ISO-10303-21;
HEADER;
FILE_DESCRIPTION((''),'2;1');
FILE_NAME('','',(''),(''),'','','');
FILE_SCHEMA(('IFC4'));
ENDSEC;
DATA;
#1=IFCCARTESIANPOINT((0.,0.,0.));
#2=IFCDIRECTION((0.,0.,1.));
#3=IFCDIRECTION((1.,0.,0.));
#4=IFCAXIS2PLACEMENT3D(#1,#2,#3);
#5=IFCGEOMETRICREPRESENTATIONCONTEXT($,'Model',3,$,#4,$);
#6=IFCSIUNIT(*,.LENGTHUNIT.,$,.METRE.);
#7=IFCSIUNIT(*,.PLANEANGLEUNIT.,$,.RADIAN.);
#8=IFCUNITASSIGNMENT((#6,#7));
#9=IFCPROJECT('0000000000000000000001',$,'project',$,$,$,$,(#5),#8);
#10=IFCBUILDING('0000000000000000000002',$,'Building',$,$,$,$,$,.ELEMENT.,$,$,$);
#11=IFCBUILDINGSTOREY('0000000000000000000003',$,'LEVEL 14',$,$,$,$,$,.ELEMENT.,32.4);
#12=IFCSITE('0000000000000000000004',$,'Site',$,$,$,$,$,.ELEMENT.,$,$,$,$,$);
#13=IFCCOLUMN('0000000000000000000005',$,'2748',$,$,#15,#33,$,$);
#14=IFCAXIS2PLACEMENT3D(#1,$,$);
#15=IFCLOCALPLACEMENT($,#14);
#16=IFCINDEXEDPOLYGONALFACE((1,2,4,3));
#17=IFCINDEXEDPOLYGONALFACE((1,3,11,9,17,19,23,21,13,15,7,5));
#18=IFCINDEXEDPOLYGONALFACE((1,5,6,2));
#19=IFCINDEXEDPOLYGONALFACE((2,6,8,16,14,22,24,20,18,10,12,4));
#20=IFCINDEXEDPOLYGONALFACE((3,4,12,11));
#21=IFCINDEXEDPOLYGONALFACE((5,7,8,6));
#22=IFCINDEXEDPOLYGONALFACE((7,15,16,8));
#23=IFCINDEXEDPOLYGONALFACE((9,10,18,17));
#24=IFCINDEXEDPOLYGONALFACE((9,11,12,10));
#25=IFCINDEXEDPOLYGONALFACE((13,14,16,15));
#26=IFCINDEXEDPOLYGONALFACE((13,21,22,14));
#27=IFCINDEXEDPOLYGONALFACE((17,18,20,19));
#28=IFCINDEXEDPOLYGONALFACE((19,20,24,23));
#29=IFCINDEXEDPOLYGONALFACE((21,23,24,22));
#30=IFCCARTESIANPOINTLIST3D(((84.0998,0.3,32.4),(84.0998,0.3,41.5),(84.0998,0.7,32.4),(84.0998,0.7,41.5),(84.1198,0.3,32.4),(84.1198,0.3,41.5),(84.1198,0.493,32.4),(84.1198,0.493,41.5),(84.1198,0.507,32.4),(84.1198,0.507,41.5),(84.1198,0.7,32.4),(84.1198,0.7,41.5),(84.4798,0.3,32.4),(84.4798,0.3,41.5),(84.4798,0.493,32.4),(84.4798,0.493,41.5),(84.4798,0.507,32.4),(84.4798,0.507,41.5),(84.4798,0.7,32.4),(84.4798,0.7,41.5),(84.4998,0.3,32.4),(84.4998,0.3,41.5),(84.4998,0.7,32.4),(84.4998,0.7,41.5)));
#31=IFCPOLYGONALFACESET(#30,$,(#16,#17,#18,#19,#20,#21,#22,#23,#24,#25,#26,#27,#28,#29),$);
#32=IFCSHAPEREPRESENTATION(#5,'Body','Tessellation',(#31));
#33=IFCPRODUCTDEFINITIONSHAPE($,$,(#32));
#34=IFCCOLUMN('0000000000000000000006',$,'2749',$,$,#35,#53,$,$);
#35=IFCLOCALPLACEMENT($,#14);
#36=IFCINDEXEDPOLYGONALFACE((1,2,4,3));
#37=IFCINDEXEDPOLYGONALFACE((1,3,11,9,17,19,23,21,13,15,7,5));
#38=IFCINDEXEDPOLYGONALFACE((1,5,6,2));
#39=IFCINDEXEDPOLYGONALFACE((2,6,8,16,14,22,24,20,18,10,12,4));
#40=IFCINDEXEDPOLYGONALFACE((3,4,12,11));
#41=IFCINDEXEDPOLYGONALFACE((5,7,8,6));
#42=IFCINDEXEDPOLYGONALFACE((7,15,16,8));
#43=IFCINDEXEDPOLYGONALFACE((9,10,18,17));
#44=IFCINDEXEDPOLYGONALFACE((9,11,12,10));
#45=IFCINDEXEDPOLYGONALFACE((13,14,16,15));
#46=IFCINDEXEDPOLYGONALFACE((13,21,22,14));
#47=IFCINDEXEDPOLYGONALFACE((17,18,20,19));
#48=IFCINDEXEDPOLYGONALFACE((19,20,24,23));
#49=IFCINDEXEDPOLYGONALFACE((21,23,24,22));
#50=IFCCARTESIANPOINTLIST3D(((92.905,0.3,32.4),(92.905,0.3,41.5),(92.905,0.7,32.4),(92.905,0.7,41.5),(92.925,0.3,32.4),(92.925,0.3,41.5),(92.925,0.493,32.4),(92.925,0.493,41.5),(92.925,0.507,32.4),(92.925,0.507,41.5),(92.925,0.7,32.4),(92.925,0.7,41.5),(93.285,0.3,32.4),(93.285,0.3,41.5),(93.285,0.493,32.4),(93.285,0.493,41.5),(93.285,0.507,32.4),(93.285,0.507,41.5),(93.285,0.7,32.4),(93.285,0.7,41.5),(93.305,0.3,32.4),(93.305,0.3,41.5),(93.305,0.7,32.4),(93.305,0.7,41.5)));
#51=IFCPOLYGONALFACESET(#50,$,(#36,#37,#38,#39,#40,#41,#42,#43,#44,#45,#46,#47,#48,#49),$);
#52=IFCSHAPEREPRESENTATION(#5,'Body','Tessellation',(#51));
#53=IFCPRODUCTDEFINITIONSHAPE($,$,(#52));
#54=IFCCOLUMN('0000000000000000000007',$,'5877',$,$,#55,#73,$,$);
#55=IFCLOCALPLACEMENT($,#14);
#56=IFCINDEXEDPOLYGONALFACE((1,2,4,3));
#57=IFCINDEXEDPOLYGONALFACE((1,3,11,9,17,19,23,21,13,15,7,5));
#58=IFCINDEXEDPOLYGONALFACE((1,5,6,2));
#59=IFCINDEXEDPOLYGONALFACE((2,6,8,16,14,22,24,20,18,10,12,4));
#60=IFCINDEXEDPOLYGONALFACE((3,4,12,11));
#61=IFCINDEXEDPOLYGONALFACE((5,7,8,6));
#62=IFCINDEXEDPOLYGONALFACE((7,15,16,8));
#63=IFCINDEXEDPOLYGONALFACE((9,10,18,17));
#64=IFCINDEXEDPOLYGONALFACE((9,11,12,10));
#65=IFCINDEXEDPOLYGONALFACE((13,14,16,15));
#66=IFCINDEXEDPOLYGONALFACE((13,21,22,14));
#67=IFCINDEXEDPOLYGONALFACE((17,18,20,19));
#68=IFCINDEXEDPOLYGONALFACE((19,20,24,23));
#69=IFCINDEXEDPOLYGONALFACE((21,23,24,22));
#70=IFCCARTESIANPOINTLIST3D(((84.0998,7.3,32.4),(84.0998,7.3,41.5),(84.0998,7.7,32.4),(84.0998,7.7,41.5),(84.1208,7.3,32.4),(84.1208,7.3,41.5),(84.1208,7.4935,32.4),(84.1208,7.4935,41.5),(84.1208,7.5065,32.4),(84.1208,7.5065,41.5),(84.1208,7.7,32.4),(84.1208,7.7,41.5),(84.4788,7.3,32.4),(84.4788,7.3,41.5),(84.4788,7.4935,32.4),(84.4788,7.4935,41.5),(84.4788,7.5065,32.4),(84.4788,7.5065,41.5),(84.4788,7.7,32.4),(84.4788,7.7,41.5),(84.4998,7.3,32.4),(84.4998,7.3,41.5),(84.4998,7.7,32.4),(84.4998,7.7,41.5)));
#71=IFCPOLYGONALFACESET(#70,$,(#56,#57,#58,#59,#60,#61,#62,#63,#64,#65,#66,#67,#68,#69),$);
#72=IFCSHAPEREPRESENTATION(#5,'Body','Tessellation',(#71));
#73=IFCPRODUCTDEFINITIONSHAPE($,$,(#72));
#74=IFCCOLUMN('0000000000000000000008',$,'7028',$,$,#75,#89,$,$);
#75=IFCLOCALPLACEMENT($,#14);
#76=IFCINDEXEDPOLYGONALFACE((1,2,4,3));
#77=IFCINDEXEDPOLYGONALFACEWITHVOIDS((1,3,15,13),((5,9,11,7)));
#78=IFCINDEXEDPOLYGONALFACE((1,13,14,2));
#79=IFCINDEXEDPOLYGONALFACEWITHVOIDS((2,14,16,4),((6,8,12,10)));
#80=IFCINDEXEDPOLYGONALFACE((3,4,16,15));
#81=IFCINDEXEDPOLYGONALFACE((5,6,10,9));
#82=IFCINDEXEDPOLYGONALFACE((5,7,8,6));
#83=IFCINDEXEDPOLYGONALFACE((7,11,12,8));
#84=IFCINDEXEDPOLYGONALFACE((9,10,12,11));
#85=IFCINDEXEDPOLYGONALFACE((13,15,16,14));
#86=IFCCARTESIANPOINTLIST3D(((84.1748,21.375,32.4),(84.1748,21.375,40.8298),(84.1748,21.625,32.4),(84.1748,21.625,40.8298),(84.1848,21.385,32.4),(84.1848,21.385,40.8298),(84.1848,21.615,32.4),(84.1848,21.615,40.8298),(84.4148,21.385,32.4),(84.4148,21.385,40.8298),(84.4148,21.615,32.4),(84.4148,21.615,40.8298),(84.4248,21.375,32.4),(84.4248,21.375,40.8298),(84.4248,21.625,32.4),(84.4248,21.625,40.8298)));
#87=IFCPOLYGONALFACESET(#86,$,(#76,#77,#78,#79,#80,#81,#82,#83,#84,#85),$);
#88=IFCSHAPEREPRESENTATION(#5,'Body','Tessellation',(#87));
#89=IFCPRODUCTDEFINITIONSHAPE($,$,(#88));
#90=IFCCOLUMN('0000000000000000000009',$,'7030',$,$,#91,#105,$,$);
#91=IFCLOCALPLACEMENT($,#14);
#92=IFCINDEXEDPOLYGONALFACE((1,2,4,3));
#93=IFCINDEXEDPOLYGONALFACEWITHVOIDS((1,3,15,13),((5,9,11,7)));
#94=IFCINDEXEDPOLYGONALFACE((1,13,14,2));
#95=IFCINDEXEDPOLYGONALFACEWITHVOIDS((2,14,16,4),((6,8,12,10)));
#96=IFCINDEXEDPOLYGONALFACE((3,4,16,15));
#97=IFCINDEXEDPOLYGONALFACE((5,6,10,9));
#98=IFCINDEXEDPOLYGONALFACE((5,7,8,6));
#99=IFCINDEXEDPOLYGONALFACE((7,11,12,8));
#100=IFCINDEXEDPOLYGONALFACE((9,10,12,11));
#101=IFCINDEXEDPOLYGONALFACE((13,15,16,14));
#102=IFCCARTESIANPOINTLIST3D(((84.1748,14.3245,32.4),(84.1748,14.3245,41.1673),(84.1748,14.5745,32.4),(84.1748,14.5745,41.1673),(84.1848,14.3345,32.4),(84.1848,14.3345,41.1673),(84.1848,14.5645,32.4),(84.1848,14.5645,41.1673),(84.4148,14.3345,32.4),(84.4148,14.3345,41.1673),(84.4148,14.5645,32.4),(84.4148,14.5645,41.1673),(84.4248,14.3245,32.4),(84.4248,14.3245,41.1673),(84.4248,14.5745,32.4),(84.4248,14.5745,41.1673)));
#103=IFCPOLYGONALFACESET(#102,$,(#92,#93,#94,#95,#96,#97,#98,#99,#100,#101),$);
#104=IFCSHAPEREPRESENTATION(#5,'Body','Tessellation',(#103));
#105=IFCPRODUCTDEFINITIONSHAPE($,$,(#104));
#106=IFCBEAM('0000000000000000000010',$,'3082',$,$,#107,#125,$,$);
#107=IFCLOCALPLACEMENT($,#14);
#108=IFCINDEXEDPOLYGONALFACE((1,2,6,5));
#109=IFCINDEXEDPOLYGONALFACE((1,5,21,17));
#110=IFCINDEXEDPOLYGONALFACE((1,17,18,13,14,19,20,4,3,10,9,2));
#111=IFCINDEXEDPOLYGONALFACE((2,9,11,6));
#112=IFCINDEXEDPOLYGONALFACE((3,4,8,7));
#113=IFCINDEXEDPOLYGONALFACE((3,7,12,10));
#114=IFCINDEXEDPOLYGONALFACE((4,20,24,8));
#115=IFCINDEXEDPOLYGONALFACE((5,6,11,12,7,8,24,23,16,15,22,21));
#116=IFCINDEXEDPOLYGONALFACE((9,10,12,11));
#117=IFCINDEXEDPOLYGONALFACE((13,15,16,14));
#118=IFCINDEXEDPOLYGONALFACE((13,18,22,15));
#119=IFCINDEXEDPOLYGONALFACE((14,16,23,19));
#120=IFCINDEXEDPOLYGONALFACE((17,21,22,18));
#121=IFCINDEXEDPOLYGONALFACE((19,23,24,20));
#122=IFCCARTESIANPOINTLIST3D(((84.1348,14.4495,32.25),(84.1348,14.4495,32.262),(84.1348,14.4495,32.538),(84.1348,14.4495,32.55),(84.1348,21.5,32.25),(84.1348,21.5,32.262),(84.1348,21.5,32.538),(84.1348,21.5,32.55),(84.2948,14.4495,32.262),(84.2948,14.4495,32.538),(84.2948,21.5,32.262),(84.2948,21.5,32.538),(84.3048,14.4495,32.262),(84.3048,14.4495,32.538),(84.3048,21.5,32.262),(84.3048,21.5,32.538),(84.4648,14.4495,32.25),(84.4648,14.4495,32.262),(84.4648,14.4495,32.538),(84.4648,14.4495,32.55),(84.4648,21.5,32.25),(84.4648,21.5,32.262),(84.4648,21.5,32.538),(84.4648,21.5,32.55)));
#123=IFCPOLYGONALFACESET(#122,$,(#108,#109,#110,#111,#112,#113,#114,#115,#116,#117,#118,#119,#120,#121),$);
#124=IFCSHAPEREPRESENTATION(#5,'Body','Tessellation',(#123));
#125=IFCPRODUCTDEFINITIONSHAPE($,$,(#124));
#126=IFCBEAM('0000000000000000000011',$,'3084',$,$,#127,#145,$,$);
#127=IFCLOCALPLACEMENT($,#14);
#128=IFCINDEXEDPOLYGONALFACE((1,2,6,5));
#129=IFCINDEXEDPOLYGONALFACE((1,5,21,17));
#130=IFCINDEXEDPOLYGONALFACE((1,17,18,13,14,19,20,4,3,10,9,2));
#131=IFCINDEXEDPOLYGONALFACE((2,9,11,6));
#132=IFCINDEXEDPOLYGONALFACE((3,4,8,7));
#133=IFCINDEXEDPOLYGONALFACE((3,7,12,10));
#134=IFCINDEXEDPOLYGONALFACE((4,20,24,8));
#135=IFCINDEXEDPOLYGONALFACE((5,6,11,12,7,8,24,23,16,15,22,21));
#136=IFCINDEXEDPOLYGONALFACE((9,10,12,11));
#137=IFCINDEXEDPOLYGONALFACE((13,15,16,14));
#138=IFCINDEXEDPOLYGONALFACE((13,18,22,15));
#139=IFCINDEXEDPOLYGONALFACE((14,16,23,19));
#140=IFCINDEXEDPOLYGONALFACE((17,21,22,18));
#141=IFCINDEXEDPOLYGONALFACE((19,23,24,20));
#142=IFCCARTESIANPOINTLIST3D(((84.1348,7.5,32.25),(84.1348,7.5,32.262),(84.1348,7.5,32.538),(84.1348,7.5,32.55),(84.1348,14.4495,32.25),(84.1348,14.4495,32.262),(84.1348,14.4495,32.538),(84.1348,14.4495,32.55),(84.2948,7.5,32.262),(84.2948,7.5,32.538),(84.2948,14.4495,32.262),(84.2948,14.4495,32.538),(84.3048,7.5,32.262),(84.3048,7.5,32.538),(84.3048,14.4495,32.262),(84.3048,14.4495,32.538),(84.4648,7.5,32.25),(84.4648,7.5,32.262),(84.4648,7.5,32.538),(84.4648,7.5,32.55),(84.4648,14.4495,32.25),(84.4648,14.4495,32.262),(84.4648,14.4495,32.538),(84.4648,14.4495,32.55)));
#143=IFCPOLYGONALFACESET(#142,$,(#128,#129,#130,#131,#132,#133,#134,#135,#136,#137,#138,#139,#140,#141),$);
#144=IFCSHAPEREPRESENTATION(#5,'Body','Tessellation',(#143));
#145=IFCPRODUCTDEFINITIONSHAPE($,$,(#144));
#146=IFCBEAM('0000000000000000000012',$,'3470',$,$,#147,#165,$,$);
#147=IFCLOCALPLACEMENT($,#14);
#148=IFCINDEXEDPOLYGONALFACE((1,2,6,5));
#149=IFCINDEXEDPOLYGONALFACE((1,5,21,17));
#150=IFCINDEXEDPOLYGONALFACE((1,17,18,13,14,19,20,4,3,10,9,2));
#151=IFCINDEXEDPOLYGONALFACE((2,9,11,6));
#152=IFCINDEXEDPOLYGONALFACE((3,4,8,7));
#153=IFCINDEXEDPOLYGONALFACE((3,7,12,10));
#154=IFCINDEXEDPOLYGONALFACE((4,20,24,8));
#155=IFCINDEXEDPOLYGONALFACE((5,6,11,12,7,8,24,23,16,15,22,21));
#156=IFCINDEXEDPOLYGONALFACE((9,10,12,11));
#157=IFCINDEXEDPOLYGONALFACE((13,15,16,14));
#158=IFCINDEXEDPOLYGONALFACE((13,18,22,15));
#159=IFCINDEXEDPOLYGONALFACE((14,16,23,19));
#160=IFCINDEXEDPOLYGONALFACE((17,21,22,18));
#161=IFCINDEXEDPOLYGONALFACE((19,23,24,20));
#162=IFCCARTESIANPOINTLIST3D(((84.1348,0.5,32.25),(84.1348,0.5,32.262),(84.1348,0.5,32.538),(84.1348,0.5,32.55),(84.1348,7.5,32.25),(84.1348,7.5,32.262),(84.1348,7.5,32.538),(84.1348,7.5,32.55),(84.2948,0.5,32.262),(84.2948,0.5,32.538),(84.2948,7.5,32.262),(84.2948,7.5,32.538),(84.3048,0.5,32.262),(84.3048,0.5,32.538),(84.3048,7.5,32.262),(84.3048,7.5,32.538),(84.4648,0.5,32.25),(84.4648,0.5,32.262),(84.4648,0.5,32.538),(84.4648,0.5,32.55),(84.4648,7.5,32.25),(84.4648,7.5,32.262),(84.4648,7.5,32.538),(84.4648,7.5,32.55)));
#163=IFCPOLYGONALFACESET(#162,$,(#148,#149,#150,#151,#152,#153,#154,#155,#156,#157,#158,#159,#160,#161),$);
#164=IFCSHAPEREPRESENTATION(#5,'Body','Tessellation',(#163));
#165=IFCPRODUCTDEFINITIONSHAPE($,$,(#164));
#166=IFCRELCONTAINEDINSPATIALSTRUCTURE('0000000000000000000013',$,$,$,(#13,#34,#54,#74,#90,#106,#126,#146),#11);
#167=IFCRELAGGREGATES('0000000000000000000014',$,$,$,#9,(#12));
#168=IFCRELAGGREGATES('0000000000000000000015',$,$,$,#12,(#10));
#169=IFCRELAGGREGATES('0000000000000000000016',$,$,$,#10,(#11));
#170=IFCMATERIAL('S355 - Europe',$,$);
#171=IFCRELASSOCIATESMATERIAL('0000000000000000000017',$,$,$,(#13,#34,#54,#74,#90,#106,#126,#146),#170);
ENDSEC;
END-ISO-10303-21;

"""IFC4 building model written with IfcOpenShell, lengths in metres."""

from ifc_helpers import new_model, si_unit, frame, origin_with_axes, origin_2d_with_axis, place, context, project, spatial, hollow_rectangle, i_section, extrude, material, material_profile, profile_set, profile_usage, element, save


model = new_model("IFC4")

# Units and contexts
model_context = context("Model", 3, world=origin_with_axes())
ifc_project = project(units=[si_unit("LENGTHUNIT", "METRE"), si_unit("PLANEANGLEUNIT", "RADIAN")], contexts=[model_context])

# Site, building, storey
site = spatial("IfcSite", under=ifc_project, Name="Site", CompositionType="ELEMENT")
building = spatial("IfcBuilding", under=site, Name="Building", CompositionType="ELEMENT")
storey = spatial("IfcBuildingStorey", under=building, Name="LEVEL 14", CompositionType="ELEMENT", Elevation=32.4)

# Columns
ifc_material = material(Name="S355 - Europe")
ifc_material_profile_1 = material_profile(ifc_material, i_section(OverallWidth=0.4, OverallDepth=0.4, WebThickness=0.014, FlangeThickness=0.02, at=origin_2d_with_axis()))
ifc_profile_set_1 = profile_set([ifc_material_profile_1])
ifc_profile_usage_1 = profile_usage(ifc_profile_set_1, cardinal=10)
column_1_placement = place(None, frame((84.2998, 0.5, 32.4), z_axis=(0.0, 0.0, 1.0), x_axis=(0.0, -1.0, 0.0)))
element("IfcColumn", 1, at=column_1_placement, inside=storey, material=ifc_profile_usage_1, Name="2748", context=model_context, shape_type="SweptSolid", body=[
    extrude(i_section(OverallWidth=0.4, OverallDepth=0.4, WebThickness=0.014, FlangeThickness=0.02, at=origin_2d_with_axis()), origin_with_axes(), (0.0, 0.0, 1.0), 9.1),
])
ifc_material_profile_2 = material_profile(ifc_material, i_section(OverallWidth=0.4, OverallDepth=0.4, WebThickness=0.014, FlangeThickness=0.02, at=origin_2d_with_axis()))
ifc_profile_set_2 = profile_set([ifc_material_profile_2])
ifc_profile_usage_2 = profile_usage(ifc_profile_set_2, cardinal=10)
column_2_placement = place(None, frame((93.105, 0.5, 32.4), z_axis=(0.0, 0.0, 1.0), x_axis=(0.0, -1.0, 0.0)))
element("IfcColumn", 2, at=column_2_placement, inside=storey, material=ifc_profile_usage_2, Name="2749", context=model_context, shape_type="SweptSolid", body=[
    extrude(i_section(OverallWidth=0.4, OverallDepth=0.4, WebThickness=0.014, FlangeThickness=0.02, at=origin_2d_with_axis()), origin_with_axes(), (0.0, 0.0, 1.0), 9.1),
])
ifc_material_profile_3 = material_profile(ifc_material, i_section(OverallWidth=0.4, OverallDepth=0.4, WebThickness=0.013, FlangeThickness=0.021, at=origin_2d_with_axis()))
ifc_profile_set_3 = profile_set([ifc_material_profile_3])
ifc_profile_usage_3 = profile_usage(ifc_profile_set_3, cardinal=10)
column_3_placement = place(None, frame((84.2998, 7.5, 32.4), z_axis=(0.0, 0.0, 1.0), x_axis=(0.0, -1.0, 0.0)))
element("IfcColumn", 3, at=column_3_placement, inside=storey, material=ifc_profile_usage_3, Name="5877", context=model_context, shape_type="SweptSolid", body=[
    extrude(i_section(OverallWidth=0.4, OverallDepth=0.4, WebThickness=0.013, FlangeThickness=0.021, at=origin_2d_with_axis()), origin_with_axes(), (0.0, 0.0, 1.0), 9.1),
])
ifc_material_profile_4 = material_profile(ifc_material, hollow_rectangle(XDim=0.25, YDim=0.25, WallThickness=0.01, at=origin_2d_with_axis()))
ifc_profile_set_4 = profile_set([ifc_material_profile_4])
ifc_profile_usage_4 = profile_usage(ifc_profile_set_4, cardinal=10)
column_4_placement = place(None, frame((84.2998, 21.5, 32.4), z_axis=(0.0, 0.0, 1.0), x_axis=(0.0, -1.0, 0.0)))
element("IfcColumn", 4, at=column_4_placement, inside=storey, material=ifc_profile_usage_4, Name="7028", context=model_context, shape_type="SweptSolid", body=[
    extrude(hollow_rectangle(XDim=0.25, YDim=0.25, WallThickness=0.01, at=origin_2d_with_axis()), origin_with_axes(), (0.0, 0.0, 1.0), 8.4298),
])
ifc_material_profile_5 = material_profile(ifc_material, hollow_rectangle(XDim=0.25, YDim=0.25, WallThickness=0.01, at=origin_2d_with_axis()))
ifc_profile_set_5 = profile_set([ifc_material_profile_5])
ifc_profile_usage_5 = profile_usage(ifc_profile_set_5, cardinal=10)
column_5_placement = place(None, frame((84.2998, 14.4495, 32.4), z_axis=(0.0, 0.0, 1.0), x_axis=(0.0, -1.0, 0.0)))
element("IfcColumn", 5, at=column_5_placement, inside=storey, material=ifc_profile_usage_5, Name="7030", context=model_context, shape_type="SweptSolid", body=[
    extrude(hollow_rectangle(XDim=0.25, YDim=0.25, WallThickness=0.01, at=origin_2d_with_axis()), origin_with_axes(), (0.0, 0.0, 1.0), 8.7673),
])

# Beams
ifc_material_profile_6 = material_profile(ifc_material, i_section(OverallWidth=0.33, OverallDepth=0.3, WebThickness=0.01, FlangeThickness=0.012, at=origin_2d_with_axis()))
ifc_profile_set_6 = profile_set([ifc_material_profile_6])
ifc_profile_usage_6 = profile_usage(ifc_profile_set_6, cardinal=10)
beam_1_placement = place(None, frame((84.2998, 21.5, 32.4), z_axis=(0.0, -1.0, 0.0), x_axis=(1.0, 0.0, 0.0)))
element("IfcBeam", 6, at=beam_1_placement, inside=storey, material=ifc_profile_usage_6, Name="3082", context=model_context, shape_type="SweptSolid", body=[
    extrude(i_section(OverallWidth=0.33, OverallDepth=0.3, WebThickness=0.01, FlangeThickness=0.012, at=origin_2d_with_axis()), origin_with_axes(), (0.0, 0.0, 1.0), 7.0505),
])
ifc_material_profile_7 = material_profile(ifc_material, i_section(OverallWidth=0.33, OverallDepth=0.3, WebThickness=0.01, FlangeThickness=0.012, at=origin_2d_with_axis()))
ifc_profile_set_7 = profile_set([ifc_material_profile_7])
ifc_profile_usage_7 = profile_usage(ifc_profile_set_7, cardinal=10)
beam_2_placement = place(None, frame((84.2998, 14.4495, 32.4), z_axis=(0.0, -1.0, 0.0), x_axis=(1.0, 0.0, 0.0)))
element("IfcBeam", 7, at=beam_2_placement, inside=storey, material=ifc_profile_usage_7, Name="3084", context=model_context, shape_type="SweptSolid", body=[
    extrude(i_section(OverallWidth=0.33, OverallDepth=0.3, WebThickness=0.01, FlangeThickness=0.012, at=origin_2d_with_axis()), origin_with_axes(), (0.0, 0.0, 1.0), 6.9495),
])
ifc_material_profile_8 = material_profile(ifc_material, i_section(OverallWidth=0.33, OverallDepth=0.3, WebThickness=0.01, FlangeThickness=0.012, at=origin_2d_with_axis()))
ifc_profile_set_8 = profile_set([ifc_material_profile_8])
ifc_profile_usage_8 = profile_usage(ifc_profile_set_8, cardinal=10)
beam_3_placement = place(None, frame((84.2998, 7.5, 32.4), z_axis=(0.0, -1.0, 0.0), x_axis=(1.0, 0.0, 0.0)))
element("IfcBeam", 8, at=beam_3_placement, inside=storey, material=ifc_profile_usage_8, Name="3470", context=model_context, shape_type="SweptSolid", body=[
    extrude(i_section(OverallWidth=0.33, OverallDepth=0.3, WebThickness=0.01, FlangeThickness=0.012, at=origin_2d_with_axis()), origin_with_axes(), (0.0, 0.0, 1.0), 7.0),
])

save(model, "model.ifc")
